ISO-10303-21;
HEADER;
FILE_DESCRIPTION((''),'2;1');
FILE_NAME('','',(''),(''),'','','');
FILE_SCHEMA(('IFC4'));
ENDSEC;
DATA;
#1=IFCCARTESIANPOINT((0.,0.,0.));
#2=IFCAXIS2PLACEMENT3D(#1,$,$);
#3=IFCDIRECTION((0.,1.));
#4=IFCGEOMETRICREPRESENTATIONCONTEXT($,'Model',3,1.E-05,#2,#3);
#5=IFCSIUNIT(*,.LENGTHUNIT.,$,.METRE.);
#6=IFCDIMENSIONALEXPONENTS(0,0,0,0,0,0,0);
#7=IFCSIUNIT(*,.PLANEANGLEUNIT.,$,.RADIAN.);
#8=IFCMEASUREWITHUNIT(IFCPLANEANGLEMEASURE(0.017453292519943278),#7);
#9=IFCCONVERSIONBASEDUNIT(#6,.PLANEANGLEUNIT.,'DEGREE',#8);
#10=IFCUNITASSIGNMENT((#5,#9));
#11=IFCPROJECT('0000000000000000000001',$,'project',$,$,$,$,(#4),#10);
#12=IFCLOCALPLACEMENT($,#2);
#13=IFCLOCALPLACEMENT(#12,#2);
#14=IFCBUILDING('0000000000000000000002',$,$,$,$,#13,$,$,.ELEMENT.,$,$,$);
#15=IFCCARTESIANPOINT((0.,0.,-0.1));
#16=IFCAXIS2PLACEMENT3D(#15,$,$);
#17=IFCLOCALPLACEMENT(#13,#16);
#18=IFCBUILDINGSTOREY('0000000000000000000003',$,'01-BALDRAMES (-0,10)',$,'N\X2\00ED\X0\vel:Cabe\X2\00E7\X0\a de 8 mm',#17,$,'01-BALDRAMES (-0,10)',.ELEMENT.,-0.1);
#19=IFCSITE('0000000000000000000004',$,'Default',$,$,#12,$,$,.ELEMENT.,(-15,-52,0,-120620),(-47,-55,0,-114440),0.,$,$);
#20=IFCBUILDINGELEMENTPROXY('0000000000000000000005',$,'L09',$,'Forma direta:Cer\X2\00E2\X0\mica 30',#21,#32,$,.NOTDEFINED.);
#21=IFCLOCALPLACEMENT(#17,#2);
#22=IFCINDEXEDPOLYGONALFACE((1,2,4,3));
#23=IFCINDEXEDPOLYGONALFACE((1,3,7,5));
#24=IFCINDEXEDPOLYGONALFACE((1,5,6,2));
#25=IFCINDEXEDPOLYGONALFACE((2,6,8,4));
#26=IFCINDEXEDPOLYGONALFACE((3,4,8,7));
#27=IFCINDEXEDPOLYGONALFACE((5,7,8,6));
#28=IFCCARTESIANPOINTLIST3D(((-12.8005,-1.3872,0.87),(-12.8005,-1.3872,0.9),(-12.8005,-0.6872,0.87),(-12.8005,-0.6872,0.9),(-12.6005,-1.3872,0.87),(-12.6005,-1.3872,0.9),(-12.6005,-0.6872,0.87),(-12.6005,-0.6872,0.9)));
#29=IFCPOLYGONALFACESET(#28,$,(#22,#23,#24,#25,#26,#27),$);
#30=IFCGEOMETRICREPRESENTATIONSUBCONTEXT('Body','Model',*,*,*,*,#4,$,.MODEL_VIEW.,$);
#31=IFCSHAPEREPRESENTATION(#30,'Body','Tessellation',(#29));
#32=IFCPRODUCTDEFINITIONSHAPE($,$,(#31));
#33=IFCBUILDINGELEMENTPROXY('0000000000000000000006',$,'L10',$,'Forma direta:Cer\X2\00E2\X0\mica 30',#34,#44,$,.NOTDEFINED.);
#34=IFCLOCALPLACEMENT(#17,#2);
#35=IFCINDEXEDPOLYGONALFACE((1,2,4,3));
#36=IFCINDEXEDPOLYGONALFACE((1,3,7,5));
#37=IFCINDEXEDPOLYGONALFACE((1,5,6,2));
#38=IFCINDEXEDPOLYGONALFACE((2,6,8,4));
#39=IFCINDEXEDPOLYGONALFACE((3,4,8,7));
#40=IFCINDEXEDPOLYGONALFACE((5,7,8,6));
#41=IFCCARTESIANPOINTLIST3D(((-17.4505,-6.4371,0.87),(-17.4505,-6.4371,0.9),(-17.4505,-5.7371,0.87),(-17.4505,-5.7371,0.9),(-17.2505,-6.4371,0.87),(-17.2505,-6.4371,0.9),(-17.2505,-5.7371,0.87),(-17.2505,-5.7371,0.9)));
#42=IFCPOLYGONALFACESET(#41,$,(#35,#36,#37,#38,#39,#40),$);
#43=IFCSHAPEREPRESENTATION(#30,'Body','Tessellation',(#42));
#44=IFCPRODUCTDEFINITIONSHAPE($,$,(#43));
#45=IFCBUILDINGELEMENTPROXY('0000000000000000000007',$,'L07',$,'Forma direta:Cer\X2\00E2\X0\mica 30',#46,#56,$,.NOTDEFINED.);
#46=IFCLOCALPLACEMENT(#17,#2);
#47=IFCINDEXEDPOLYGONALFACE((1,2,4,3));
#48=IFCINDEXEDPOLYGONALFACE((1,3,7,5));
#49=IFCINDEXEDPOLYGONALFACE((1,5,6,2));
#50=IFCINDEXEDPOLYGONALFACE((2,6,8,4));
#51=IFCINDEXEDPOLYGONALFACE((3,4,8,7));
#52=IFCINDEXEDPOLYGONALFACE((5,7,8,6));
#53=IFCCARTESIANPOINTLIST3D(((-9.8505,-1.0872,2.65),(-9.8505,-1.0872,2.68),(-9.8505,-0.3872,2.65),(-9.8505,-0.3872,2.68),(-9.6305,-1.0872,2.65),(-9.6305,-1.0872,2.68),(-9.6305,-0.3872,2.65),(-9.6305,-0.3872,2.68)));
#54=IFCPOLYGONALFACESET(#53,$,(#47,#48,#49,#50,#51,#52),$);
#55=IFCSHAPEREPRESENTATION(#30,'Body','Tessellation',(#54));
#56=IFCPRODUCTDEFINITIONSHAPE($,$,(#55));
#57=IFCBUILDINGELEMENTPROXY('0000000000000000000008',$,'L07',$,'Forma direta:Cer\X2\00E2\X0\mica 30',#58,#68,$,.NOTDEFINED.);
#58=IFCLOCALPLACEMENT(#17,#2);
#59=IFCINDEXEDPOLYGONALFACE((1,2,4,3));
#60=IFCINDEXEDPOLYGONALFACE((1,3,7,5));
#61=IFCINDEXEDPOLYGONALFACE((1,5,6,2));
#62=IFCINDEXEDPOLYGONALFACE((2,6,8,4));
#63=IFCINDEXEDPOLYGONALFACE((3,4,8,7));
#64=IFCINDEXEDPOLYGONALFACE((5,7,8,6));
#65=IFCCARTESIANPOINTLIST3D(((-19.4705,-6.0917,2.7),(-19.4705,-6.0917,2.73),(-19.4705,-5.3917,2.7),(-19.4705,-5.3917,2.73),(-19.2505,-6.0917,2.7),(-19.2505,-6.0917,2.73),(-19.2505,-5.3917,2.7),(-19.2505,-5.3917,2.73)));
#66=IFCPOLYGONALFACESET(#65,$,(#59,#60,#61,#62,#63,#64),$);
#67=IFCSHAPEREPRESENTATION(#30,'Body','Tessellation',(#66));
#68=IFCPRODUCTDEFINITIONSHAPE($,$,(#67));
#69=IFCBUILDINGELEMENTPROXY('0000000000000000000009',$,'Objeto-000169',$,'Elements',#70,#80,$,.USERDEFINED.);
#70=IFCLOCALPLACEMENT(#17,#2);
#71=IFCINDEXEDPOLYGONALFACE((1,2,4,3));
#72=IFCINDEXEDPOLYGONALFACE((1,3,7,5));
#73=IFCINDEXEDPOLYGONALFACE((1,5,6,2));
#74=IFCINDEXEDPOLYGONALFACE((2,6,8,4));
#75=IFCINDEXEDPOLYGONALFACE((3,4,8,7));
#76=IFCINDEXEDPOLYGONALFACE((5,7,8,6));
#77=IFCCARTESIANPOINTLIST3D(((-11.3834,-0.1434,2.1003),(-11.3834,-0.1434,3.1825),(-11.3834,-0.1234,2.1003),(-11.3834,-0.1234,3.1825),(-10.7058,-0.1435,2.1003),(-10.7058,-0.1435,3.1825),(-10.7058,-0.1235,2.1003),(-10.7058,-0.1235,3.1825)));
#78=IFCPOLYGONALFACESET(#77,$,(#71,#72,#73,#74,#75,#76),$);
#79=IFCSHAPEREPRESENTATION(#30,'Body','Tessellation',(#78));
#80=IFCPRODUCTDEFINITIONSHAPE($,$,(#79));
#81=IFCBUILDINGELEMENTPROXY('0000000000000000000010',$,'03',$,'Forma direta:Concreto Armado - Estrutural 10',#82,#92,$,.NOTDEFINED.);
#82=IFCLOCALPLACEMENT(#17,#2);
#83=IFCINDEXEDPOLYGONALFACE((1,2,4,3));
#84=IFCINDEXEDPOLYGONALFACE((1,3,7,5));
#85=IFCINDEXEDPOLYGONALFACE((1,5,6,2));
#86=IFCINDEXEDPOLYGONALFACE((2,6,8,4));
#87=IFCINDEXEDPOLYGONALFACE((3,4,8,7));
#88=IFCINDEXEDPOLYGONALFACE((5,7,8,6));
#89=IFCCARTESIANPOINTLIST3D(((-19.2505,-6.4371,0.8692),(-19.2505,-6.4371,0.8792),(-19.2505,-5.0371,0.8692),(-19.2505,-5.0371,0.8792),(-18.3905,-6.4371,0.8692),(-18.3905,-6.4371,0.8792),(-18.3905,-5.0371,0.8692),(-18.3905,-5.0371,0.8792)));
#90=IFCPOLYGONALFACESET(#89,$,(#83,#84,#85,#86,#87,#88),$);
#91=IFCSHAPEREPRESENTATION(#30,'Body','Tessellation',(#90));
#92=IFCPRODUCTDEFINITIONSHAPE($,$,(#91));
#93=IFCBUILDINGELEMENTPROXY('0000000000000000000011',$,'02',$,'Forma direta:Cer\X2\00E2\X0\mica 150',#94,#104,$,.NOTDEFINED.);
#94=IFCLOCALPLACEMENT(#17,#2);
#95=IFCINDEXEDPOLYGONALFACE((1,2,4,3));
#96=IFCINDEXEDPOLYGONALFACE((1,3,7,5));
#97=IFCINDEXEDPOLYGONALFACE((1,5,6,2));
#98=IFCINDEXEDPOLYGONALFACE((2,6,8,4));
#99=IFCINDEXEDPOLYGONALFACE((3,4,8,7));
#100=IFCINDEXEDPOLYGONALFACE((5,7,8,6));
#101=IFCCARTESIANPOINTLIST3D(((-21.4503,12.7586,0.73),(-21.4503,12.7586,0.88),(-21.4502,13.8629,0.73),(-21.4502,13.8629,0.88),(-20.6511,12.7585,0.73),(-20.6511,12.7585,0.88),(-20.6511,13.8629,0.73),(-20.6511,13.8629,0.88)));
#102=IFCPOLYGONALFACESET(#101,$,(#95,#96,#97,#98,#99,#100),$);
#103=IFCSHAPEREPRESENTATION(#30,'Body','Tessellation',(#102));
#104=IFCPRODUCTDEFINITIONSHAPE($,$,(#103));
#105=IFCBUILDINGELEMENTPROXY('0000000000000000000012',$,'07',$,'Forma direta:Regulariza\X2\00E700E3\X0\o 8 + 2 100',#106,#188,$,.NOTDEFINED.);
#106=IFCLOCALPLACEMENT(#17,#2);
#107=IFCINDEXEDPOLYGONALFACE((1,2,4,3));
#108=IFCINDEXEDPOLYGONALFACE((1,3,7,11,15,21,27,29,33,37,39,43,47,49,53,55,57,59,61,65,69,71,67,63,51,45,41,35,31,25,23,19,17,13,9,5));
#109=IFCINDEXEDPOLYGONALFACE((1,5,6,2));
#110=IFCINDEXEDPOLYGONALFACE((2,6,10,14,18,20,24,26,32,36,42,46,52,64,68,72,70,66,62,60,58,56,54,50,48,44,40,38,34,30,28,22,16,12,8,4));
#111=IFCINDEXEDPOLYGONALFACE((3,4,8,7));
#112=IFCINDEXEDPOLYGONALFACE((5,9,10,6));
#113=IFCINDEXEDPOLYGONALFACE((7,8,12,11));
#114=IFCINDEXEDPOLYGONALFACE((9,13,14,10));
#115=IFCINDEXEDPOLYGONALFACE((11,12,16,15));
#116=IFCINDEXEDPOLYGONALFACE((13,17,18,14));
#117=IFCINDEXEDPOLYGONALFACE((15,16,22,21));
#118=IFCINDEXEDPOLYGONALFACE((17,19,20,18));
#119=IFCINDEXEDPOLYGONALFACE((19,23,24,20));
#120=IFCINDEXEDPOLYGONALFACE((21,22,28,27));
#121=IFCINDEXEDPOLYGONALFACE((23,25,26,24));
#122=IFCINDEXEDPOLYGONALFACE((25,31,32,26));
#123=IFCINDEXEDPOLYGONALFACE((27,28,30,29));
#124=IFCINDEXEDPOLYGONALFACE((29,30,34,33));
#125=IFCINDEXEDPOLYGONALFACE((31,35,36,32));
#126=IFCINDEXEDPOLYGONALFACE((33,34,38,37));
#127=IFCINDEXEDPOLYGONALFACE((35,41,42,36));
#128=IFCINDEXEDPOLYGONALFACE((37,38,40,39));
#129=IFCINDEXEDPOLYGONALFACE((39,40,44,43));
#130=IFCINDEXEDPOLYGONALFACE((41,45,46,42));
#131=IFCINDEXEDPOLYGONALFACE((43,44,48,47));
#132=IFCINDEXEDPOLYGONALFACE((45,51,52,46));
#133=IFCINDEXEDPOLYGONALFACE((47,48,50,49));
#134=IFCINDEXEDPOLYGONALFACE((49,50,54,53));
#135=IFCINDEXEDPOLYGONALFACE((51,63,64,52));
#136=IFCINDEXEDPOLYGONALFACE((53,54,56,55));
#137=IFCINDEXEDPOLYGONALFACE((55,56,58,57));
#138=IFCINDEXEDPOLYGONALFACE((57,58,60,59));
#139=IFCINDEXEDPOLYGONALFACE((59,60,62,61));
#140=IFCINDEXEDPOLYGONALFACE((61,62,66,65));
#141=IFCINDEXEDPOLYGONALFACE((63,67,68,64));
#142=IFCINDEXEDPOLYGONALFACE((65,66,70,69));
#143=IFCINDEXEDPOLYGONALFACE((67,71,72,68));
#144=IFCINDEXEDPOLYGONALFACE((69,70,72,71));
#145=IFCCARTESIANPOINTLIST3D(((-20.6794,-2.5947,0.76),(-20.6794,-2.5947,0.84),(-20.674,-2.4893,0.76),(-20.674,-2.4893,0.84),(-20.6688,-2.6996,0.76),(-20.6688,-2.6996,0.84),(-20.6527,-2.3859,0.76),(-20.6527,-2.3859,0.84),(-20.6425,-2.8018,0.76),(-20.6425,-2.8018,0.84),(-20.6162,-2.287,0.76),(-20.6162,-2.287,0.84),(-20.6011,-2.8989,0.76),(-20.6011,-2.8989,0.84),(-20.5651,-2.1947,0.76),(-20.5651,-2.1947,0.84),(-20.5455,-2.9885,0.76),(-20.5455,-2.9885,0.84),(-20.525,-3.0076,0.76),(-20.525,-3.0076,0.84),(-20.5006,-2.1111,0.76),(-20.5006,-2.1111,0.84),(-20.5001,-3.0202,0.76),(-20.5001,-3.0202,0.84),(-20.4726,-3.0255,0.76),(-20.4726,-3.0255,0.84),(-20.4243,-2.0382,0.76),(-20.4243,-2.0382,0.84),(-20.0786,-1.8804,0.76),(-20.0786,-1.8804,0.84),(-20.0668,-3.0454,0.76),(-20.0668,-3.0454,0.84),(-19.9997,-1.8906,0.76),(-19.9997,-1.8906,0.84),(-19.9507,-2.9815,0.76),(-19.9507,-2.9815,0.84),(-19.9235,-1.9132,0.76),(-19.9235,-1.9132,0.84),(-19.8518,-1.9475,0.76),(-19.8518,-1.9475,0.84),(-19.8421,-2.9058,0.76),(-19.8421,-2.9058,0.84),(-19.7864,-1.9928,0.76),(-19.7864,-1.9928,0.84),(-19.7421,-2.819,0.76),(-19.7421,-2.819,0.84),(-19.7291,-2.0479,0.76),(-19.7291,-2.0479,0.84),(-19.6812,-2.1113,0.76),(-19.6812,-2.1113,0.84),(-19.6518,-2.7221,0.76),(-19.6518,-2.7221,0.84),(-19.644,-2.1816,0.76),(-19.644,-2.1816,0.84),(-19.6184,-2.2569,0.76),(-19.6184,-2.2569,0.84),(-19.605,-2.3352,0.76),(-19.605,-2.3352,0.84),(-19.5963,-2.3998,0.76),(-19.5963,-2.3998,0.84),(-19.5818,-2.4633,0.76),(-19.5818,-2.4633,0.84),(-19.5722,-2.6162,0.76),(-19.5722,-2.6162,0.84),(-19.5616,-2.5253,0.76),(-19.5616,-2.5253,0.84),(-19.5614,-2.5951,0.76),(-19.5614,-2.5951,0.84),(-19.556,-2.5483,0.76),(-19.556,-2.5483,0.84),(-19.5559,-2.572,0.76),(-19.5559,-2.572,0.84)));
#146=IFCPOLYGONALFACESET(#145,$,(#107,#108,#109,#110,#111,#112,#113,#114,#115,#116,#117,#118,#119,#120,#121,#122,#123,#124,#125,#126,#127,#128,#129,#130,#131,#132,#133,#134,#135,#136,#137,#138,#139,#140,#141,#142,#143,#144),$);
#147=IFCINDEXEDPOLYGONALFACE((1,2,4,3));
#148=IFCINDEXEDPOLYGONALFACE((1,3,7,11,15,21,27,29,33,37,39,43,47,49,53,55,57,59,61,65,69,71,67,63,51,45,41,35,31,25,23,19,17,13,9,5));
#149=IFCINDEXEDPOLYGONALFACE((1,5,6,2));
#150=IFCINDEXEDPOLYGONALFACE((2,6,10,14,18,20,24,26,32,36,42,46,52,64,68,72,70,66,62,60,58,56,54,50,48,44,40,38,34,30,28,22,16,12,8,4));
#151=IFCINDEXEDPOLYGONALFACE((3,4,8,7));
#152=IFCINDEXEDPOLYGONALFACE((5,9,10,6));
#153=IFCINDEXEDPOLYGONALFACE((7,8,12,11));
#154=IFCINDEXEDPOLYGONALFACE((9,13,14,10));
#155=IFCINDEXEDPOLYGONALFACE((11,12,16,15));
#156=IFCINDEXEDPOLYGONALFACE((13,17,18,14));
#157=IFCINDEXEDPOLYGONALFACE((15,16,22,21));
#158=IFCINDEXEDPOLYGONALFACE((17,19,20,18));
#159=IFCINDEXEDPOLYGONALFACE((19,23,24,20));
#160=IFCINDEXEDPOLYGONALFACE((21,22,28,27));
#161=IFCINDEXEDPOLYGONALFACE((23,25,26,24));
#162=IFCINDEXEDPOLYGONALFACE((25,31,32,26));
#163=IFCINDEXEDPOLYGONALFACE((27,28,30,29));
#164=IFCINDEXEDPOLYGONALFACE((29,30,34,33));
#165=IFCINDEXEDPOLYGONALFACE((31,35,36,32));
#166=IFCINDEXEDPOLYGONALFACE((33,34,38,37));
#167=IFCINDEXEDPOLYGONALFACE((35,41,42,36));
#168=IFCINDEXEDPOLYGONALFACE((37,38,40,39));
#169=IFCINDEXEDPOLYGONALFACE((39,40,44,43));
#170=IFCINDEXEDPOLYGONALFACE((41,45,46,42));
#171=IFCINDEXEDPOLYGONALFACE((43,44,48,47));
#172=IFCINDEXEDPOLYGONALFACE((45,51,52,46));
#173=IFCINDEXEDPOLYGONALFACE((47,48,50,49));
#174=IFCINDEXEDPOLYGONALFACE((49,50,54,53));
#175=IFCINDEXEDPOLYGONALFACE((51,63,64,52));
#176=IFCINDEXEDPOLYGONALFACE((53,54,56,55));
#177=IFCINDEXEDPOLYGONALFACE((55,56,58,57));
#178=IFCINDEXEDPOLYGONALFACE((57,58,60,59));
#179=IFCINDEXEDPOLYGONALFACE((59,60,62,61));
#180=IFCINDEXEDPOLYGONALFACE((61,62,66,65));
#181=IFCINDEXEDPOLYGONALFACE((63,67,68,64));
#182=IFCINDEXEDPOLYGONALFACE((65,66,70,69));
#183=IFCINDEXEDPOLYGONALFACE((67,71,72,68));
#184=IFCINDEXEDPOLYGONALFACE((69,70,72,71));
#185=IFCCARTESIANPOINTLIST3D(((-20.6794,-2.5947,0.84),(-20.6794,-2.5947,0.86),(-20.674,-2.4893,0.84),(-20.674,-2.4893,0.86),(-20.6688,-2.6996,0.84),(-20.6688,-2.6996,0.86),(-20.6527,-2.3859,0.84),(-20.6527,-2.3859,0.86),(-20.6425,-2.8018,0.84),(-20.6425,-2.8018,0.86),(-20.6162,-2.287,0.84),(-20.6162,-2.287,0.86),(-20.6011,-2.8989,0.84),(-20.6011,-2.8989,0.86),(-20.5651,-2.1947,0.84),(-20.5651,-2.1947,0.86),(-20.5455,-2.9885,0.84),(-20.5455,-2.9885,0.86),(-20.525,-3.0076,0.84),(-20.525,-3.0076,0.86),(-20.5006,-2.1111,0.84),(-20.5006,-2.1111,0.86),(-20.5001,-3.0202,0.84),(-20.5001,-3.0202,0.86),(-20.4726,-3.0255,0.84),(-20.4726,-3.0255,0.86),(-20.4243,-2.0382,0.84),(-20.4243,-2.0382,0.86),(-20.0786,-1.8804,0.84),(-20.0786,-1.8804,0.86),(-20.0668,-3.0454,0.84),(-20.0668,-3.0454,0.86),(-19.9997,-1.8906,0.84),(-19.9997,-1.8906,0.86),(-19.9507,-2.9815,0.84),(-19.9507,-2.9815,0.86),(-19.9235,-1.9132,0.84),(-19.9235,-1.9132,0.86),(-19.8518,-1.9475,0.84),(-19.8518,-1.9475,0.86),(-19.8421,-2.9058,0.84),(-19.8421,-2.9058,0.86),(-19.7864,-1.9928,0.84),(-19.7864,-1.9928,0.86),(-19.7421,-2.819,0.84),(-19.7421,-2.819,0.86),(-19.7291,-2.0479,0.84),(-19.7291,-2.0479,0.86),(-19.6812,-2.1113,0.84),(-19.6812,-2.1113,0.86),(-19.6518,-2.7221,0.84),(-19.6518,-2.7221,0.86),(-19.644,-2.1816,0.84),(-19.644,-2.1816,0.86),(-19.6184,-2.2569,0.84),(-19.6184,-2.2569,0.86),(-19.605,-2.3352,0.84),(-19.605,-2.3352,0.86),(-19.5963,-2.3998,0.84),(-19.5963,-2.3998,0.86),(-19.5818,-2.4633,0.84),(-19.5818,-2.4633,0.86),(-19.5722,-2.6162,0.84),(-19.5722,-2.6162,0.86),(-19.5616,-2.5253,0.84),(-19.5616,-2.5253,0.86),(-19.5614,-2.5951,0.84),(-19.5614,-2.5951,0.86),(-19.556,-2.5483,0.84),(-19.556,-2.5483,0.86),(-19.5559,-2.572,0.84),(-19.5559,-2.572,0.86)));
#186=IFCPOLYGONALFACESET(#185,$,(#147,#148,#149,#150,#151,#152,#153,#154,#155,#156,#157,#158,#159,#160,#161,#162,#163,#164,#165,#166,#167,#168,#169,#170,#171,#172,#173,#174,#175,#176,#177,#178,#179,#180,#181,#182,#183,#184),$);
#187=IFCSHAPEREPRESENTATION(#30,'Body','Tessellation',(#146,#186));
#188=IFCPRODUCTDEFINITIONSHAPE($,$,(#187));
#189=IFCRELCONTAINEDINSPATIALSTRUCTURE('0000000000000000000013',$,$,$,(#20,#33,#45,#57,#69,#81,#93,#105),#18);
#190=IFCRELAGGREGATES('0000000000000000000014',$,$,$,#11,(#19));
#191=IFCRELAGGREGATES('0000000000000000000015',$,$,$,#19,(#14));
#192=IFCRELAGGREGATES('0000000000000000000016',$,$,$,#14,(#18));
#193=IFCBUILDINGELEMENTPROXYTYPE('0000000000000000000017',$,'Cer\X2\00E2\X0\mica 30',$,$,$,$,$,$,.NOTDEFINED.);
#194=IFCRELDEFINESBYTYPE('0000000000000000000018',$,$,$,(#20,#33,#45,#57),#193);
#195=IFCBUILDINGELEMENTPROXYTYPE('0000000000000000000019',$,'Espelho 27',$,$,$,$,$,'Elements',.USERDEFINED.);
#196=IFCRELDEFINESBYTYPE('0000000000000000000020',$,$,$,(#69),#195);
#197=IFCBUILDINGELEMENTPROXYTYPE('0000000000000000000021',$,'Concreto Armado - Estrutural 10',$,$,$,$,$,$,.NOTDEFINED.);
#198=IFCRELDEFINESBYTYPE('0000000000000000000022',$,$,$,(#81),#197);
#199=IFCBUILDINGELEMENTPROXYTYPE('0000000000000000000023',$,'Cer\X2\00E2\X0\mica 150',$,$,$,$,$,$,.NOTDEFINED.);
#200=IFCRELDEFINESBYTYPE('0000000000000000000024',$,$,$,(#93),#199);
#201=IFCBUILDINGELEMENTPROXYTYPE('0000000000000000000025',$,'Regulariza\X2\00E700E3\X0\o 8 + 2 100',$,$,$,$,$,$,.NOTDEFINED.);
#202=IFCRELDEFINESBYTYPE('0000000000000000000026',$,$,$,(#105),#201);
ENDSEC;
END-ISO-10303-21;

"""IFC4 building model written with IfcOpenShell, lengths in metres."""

from ifc_helpers import new_model, entity, si_unit, converted_unit, direction, frame, origin, place, context, subcontext, project, spatial, line, arc, indexed_curve, outline, extrude, type_object, element, save


model = new_model("IFC4")

# Units and contexts
model_context = context("Model", 3, precision=1e-05, world=origin(), true_north=direction((0.0, 1.0)))
body_context = subcontext(model_context, "Body", "Model", "MODEL_VIEW")
ifc_project = project(units=[si_unit("LENGTHUNIT", "METRE"), converted_unit("PLANEANGLEUNIT", "DEGREE", entity("IfcPlaneAngleMeasure", 0.017453292519943278), si_unit("PLANEANGLEUNIT", "RADIAN"), dimensions=[0, 0, 0, 0, 0, 0, 0])], contexts=[model_context])

# Site, building, storey
site_placement = place(None, origin())
site = spatial("IfcSite", under=ifc_project, at=site_placement, Name="Default", CompositionType="ELEMENT", RefLatitude=(-15, -52, 0, -120620), RefLongitude=(-47, -55, 0, -114440), RefElevation=0.0)
building_placement = place(site_placement, origin())
building = spatial("IfcBuilding", under=site, at=building_placement, CompositionType="ELEMENT")
storey_placement = place(building_placement, frame((0.0, 0.0, -0.1)))
storey = spatial("IfcBuildingStorey", under=building, at=storey_placement, Name="01-BALDRAMES (-0,10)", ObjectType="Nível:Cabeça de 8 mm", LongName="01-BALDRAMES (-0,10)", CompositionType="ELEMENT", Elevation=-0.1)

# Building element proxies
building_element_proxy_type_1 = type_object("IfcBuildingElementProxyType", Name="Cerâmica 30", PredefinedType="NOTDEFINED")
proxy_1_placement = place(storey_placement, origin())
element("IfcBuildingElementProxy", 1, at=proxy_1_placement, inside=storey, type_object=building_element_proxy_type_1, Name="L09", ObjectType="Forma direta:Cerâmica 30", PredefinedType="NOTDEFINED", context=body_context, shape_type="SweptSolid", body=[
    extrude(outline(indexed_curve([(-0.35, -0.1), (0.35, -0.1), (0.35, 0.1), (-0.35, 0.1), (-0.35, -0.1)], self_intersect=False)), frame((-12.7005, -1.0372, 0.87), z_axis=(0.0, 0.0, 1.0), x_axis=(0.000013, 1.0, 0.0)), (0.0, 0.0, 1.0), 0.03),
])
proxy_2_placement = place(storey_placement, origin())
element("IfcBuildingElementProxy", 2, at=proxy_2_placement, inside=storey, type_object=building_element_proxy_type_1, Name="L10", ObjectType="Forma direta:Cerâmica 30", PredefinedType="NOTDEFINED", context=body_context, shape_type="SweptSolid", body=[
    extrude(outline(indexed_curve([(-0.35, -0.1), (0.35, -0.1), (0.35, 0.1), (-0.35, 0.1), (-0.35, -0.1)], self_intersect=False)), frame((-17.3505, -6.0871, 0.87), z_axis=(0.0, 0.0, 1.0), x_axis=(0.000013, 1.0, 0.0)), (0.0, 0.0, 1.0), 0.03),
])
proxy_3_placement = place(storey_placement, origin())
element("IfcBuildingElementProxy", 3, at=proxy_3_placement, inside=storey, type_object=building_element_proxy_type_1, Name="L07", ObjectType="Forma direta:Cerâmica 30", PredefinedType="NOTDEFINED", context=body_context, shape_type="SweptSolid", body=[
    extrude(outline(indexed_curve([(-0.35, -0.11), (0.35, -0.11), (0.35, 0.11), (-0.35, 0.11), (-0.35, -0.11)], self_intersect=False)), frame((-9.7405, -0.7372, 2.65), z_axis=(0.0, 0.0, 1.0), x_axis=(-0.000006, 1.0, 0.0)), (0.0, 0.0, 1.0), 0.03),
])
proxy_4_placement = place(storey_placement, origin())
element("IfcBuildingElementProxy", 4, at=proxy_4_placement, inside=storey, type_object=building_element_proxy_type_1, Name="L07", ObjectType="Forma direta:Cerâmica 30", PredefinedType="NOTDEFINED", context=body_context, shape_type="SweptSolid", body=[
    extrude(outline(indexed_curve([(-0.35, -0.11), (0.35, -0.11), (0.35, 0.11), (-0.35, 0.11), (-0.35, -0.11)], self_intersect=False)), frame((-19.3605, -5.7417, 2.7), z_axis=(0.0, 0.0, 1.0), x_axis=(-0.000006, 1.0, 0.0)), (0.0, 0.0, 1.0), 0.03),
])
building_element_proxy_type_2 = type_object("IfcBuildingElementProxyType", Name="Espelho 27", ElementType="Elements", PredefinedType="USERDEFINED")
proxy_5_placement = place(storey_placement, origin())
element("IfcBuildingElementProxy", 5, at=proxy_5_placement, inside=storey, type_object=building_element_proxy_type_2, Name="Objeto-000169", ObjectType="Elements", PredefinedType="USERDEFINED", context=body_context, shape_type="SweptSolid", body=[
    extrude(outline(indexed_curve([(-0.3388, -0.01), (0.3388, -0.01), (0.3388, 0.01), (-0.3388, 0.01), (-0.3388, -0.01)], self_intersect=False)), frame((-11.0446, -0.1335, 2.1003), z_axis=(0.0, 0.0, 1.0), x_axis=(-1.0, 0.000013, 0.0)), (0.0, 0.0, 1.0), 1.0822),
])
building_element_proxy_type_3 = type_object("IfcBuildingElementProxyType", Name="Concreto Armado - Estrutural 10", PredefinedType="NOTDEFINED")
proxy_6_placement = place(storey_placement, origin())
element("IfcBuildingElementProxy", 6, at=proxy_6_placement, inside=storey, type_object=building_element_proxy_type_3, Name="03", ObjectType="Forma direta:Concreto Armado - Estrutural 10", PredefinedType="NOTDEFINED", context=body_context, shape_type="SweptSolid", body=[
    extrude(outline(indexed_curve([(-0.43, -0.7), (0.43, -0.7), (0.43, 0.7), (-0.43, 0.7), (-0.43, -0.7)], self_intersect=False)), frame((-18.8205, -5.7371, 0.8692)), (0.0, 0.0, 1.0), 0.01),
])
building_element_proxy_type_4 = type_object("IfcBuildingElementProxyType", Name="Cerâmica 150", PredefinedType="NOTDEFINED")
proxy_7_placement = place(storey_placement, origin())
element("IfcBuildingElementProxy", 7, at=proxy_7_placement, inside=storey, type_object=building_element_proxy_type_4, Name="02", ObjectType="Forma direta:Cerâmica 150", PredefinedType="NOTDEFINED", context=body_context, shape_type="SweptSolid", body=[
    extrude(outline(indexed_curve([(-0.5522, -0.3996), (0.5522, -0.3996), (0.5522, 0.3996), (-0.5522, 0.3996), (-0.5522, -0.3996)], self_intersect=False)), frame((-21.0507, 13.3107, 0.73), z_axis=(0.0, 0.0, 1.0), x_axis=(0.000013, 1.0, 0.0)), (0.0, 0.0, 1.0), 0.15),
])
building_element_proxy_type_5 = type_object("IfcBuildingElementProxyType", Name="Regularização 8 + 2 100", PredefinedType="NOTDEFINED")
proxy_8_placement = place(storey_placement, origin())
element("IfcBuildingElementProxy", 8, at=proxy_8_placement, inside=storey, type_object=building_element_proxy_type_5, Name="07", ObjectType="Forma direta:Regularização 8 + 2 100", PredefinedType="NOTDEFINED", context=body_context, shape_type="SweptSolid", body=[
    extrude(outline(indexed_curve([(0.6639, 0.0179), (0.6551, 0.0588), (0.6305, 0.0925), (0.3276, 0.3633), (-0.0011, 0.3957), (-0.3268, 0.341), (-0.3673, 0.3169), (-0.3923, 0.277), (-0.4293, 0.1866), (-0.4782, 0.102), (-0.5592, -0.239), (-0.3964, -0.5495), (-0.0283, -0.6444), (0.4495, -0.4509)], segments=[arc(1, 2, 3), line(3, 4), arc(4, 5, 6), arc(6, 7, 8), arc(8, 9, 10), arc(10, 11, 12), line(12, 13), arc(13, 14, 1)], self_intersect=False)), frame((-20.0408, -2.5568, 0.76), z_axis=(0.0, 0.0, 1.0), x_axis=(-0.777156, -0.629308, 0.0)), (0.0, 0.0, 1.0), 0.08),
    extrude(outline(indexed_curve([(0.6639, 0.0179), (0.6551, 0.0588), (0.6305, 0.0925), (0.3276, 0.3633), (-0.0011, 0.3957), (-0.3268, 0.341), (-0.3673, 0.3169), (-0.3923, 0.277), (-0.4293, 0.1866), (-0.4782, 0.102), (-0.5592, -0.239), (-0.3964, -0.5495), (-0.0283, -0.6444), (0.4495, -0.4509)], segments=[arc(1, 2, 3), line(3, 4), arc(4, 5, 6), arc(6, 7, 8), arc(8, 9, 10), arc(10, 11, 12), line(12, 13), arc(13, 14, 1)], self_intersect=False)), frame((-20.0408, -2.5568, 0.84), z_axis=(0.0, 0.0, 1.0), x_axis=(-0.777156, -0.629308, 0.0)), (0.0, 0.0, 1.0), 0.02),
])

save(model, "model.ifc")
